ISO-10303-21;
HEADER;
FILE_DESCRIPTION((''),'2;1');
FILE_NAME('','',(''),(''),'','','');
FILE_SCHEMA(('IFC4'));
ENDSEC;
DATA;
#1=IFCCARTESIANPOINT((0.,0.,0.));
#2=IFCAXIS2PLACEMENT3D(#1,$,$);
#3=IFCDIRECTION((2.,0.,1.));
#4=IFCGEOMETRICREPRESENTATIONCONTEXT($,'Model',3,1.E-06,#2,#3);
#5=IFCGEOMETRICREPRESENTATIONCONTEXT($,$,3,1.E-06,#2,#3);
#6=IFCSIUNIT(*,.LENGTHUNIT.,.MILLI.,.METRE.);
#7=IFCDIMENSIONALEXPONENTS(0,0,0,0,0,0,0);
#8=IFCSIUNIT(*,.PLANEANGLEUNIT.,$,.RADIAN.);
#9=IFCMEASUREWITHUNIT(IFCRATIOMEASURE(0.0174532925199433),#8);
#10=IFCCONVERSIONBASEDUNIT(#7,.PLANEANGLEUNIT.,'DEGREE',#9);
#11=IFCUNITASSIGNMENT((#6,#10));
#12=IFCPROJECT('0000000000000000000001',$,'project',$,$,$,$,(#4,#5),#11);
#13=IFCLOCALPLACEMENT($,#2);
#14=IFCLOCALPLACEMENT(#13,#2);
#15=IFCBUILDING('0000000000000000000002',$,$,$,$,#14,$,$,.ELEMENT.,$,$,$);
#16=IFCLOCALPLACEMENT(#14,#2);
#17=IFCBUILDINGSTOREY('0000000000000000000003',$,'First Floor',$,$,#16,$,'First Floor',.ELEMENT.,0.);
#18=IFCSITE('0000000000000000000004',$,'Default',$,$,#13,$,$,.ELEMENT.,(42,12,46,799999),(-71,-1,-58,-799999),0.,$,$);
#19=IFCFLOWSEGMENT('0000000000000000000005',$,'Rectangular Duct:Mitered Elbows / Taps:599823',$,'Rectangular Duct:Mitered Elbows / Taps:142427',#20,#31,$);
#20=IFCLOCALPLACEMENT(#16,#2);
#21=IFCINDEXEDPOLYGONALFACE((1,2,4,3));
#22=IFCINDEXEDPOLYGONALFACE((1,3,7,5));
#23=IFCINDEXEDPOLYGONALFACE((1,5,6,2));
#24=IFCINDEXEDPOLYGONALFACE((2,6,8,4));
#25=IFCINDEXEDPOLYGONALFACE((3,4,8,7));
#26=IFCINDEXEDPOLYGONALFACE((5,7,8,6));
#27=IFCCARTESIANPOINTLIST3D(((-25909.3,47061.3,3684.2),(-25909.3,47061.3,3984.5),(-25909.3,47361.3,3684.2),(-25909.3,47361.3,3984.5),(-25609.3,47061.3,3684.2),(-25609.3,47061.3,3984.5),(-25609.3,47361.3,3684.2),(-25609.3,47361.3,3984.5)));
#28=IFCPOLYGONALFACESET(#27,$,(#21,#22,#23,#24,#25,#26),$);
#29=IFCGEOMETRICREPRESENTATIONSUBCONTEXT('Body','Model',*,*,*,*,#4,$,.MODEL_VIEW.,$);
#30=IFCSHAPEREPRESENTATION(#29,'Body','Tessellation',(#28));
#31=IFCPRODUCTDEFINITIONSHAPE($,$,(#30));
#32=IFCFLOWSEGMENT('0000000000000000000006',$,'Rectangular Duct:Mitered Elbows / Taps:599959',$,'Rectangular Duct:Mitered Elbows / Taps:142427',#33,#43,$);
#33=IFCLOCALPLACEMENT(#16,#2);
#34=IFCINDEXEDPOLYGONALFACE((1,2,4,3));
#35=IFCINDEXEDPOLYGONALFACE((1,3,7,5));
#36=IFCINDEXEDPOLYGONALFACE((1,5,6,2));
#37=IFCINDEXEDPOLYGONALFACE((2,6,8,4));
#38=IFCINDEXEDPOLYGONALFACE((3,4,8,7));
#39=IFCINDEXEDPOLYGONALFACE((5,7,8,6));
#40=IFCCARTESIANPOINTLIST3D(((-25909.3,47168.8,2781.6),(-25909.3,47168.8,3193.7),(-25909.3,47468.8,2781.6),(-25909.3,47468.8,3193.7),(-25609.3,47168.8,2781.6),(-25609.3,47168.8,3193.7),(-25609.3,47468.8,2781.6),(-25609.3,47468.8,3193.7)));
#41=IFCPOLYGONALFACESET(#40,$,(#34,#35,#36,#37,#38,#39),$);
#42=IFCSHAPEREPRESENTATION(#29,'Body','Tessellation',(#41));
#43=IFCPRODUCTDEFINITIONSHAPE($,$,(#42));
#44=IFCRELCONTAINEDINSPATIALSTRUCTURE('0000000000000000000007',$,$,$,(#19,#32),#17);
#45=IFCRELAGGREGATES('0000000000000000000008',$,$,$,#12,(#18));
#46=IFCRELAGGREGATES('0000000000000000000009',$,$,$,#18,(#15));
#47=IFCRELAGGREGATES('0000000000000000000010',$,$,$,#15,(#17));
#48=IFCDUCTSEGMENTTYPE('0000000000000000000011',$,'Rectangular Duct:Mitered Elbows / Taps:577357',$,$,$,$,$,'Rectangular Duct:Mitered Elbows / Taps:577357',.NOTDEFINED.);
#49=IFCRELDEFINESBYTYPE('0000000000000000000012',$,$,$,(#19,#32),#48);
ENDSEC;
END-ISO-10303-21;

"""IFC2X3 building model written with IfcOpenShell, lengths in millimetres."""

from ifc_helpers import new_model, entity, si_unit, converted_unit, direction, frame, origin, origin_2d_with_axis, place, context, subcontext, project, spatial, rectangle, extrude, type_object, element, save


model = new_model("IFC2X3")

# Units and contexts
model_context = context("Model", 3, precision=1e-06, world=origin(), true_north=direction((2.0, 0.0, 1.0)))
context_of_model = context(None, 3, precision=1e-06, world=origin(), true_north=direction((2.0, 0.0, 1.0)))
body_context = subcontext(model_context, "Body", "Model", "MODEL_VIEW")
ifc_project = project(units=[si_unit("LENGTHUNIT", "METRE", prefix="MILLI"), converted_unit("PLANEANGLEUNIT", "DEGREE", entity("IfcRatioMeasure", 0.0174532925199433), si_unit("PLANEANGLEUNIT", "RADIAN"), dimensions=[0, 0, 0, 0, 0, 0, 0])], contexts=[model_context, context_of_model])

# Site, building, storey
site_placement = place(None, origin())
site = spatial("IfcSite", under=ifc_project, at=site_placement, Name="Default", CompositionType="ELEMENT", RefLatitude=(42, 12, 46, 799999), RefLongitude=(-71, -1, -58, -799999), RefElevation=0.0)
building_placement = place(site_placement, origin())
building = spatial("IfcBuilding", under=site, at=building_placement, CompositionType="ELEMENT")
storey_placement = place(building_placement, origin())
storey = spatial("IfcBuildingStorey", under=building, at=storey_placement, Name="First Floor", LongName="First Floor", CompositionType="ELEMENT", Elevation=0.0)

# Flow segments
duct_segment_type_1 = type_object("IfcDuctSegmentType", Name="Rectangular Duct:Mitered Elbows / Taps:577357", ElementType="Rectangular Duct:Mitered Elbows / Taps:577357", PredefinedType="NOTDEFINED")
flow_segment_1_placement = place(storey_placement, origin())
element("IfcFlowSegment", 1, at=flow_segment_1_placement, inside=storey, type_object=duct_segment_type_1, Name="Rectangular Duct:Mitered Elbows / Taps:599823", ObjectType="Rectangular Duct:Mitered Elbows / Taps:142427", context=body_context, shape_type="SweptSolid", body=[
    extrude(rectangle(XDim=300.0, YDim=300.0, at=origin_2d_with_axis()), frame((-25759.3, 47211.3, 3684.2), z_axis=(0.0, 0.0, 1.0), x_axis=(0.0, -1.0, 0.0)), (0.0, 0.0, 1.0), 300.3),
])
flow_segment_2_placement = place(storey_placement, origin())
element("IfcFlowSegment", 2, at=flow_segment_2_placement, inside=storey, type_object=duct_segment_type_1, Name="Rectangular Duct:Mitered Elbows / Taps:599959", ObjectType="Rectangular Duct:Mitered Elbows / Taps:142427", context=body_context, shape_type="SweptSolid", body=[
    extrude(rectangle(XDim=300.0, YDim=300.0, at=origin_2d_with_axis()), frame((-25759.3, 47318.8, 2781.6), z_axis=(0.0, 0.0, 1.0), x_axis=(-1.0, 0.0, 0.0)), (0.0, 0.0, 1.0), 412.1),
])

save(model, "model.ifc")
